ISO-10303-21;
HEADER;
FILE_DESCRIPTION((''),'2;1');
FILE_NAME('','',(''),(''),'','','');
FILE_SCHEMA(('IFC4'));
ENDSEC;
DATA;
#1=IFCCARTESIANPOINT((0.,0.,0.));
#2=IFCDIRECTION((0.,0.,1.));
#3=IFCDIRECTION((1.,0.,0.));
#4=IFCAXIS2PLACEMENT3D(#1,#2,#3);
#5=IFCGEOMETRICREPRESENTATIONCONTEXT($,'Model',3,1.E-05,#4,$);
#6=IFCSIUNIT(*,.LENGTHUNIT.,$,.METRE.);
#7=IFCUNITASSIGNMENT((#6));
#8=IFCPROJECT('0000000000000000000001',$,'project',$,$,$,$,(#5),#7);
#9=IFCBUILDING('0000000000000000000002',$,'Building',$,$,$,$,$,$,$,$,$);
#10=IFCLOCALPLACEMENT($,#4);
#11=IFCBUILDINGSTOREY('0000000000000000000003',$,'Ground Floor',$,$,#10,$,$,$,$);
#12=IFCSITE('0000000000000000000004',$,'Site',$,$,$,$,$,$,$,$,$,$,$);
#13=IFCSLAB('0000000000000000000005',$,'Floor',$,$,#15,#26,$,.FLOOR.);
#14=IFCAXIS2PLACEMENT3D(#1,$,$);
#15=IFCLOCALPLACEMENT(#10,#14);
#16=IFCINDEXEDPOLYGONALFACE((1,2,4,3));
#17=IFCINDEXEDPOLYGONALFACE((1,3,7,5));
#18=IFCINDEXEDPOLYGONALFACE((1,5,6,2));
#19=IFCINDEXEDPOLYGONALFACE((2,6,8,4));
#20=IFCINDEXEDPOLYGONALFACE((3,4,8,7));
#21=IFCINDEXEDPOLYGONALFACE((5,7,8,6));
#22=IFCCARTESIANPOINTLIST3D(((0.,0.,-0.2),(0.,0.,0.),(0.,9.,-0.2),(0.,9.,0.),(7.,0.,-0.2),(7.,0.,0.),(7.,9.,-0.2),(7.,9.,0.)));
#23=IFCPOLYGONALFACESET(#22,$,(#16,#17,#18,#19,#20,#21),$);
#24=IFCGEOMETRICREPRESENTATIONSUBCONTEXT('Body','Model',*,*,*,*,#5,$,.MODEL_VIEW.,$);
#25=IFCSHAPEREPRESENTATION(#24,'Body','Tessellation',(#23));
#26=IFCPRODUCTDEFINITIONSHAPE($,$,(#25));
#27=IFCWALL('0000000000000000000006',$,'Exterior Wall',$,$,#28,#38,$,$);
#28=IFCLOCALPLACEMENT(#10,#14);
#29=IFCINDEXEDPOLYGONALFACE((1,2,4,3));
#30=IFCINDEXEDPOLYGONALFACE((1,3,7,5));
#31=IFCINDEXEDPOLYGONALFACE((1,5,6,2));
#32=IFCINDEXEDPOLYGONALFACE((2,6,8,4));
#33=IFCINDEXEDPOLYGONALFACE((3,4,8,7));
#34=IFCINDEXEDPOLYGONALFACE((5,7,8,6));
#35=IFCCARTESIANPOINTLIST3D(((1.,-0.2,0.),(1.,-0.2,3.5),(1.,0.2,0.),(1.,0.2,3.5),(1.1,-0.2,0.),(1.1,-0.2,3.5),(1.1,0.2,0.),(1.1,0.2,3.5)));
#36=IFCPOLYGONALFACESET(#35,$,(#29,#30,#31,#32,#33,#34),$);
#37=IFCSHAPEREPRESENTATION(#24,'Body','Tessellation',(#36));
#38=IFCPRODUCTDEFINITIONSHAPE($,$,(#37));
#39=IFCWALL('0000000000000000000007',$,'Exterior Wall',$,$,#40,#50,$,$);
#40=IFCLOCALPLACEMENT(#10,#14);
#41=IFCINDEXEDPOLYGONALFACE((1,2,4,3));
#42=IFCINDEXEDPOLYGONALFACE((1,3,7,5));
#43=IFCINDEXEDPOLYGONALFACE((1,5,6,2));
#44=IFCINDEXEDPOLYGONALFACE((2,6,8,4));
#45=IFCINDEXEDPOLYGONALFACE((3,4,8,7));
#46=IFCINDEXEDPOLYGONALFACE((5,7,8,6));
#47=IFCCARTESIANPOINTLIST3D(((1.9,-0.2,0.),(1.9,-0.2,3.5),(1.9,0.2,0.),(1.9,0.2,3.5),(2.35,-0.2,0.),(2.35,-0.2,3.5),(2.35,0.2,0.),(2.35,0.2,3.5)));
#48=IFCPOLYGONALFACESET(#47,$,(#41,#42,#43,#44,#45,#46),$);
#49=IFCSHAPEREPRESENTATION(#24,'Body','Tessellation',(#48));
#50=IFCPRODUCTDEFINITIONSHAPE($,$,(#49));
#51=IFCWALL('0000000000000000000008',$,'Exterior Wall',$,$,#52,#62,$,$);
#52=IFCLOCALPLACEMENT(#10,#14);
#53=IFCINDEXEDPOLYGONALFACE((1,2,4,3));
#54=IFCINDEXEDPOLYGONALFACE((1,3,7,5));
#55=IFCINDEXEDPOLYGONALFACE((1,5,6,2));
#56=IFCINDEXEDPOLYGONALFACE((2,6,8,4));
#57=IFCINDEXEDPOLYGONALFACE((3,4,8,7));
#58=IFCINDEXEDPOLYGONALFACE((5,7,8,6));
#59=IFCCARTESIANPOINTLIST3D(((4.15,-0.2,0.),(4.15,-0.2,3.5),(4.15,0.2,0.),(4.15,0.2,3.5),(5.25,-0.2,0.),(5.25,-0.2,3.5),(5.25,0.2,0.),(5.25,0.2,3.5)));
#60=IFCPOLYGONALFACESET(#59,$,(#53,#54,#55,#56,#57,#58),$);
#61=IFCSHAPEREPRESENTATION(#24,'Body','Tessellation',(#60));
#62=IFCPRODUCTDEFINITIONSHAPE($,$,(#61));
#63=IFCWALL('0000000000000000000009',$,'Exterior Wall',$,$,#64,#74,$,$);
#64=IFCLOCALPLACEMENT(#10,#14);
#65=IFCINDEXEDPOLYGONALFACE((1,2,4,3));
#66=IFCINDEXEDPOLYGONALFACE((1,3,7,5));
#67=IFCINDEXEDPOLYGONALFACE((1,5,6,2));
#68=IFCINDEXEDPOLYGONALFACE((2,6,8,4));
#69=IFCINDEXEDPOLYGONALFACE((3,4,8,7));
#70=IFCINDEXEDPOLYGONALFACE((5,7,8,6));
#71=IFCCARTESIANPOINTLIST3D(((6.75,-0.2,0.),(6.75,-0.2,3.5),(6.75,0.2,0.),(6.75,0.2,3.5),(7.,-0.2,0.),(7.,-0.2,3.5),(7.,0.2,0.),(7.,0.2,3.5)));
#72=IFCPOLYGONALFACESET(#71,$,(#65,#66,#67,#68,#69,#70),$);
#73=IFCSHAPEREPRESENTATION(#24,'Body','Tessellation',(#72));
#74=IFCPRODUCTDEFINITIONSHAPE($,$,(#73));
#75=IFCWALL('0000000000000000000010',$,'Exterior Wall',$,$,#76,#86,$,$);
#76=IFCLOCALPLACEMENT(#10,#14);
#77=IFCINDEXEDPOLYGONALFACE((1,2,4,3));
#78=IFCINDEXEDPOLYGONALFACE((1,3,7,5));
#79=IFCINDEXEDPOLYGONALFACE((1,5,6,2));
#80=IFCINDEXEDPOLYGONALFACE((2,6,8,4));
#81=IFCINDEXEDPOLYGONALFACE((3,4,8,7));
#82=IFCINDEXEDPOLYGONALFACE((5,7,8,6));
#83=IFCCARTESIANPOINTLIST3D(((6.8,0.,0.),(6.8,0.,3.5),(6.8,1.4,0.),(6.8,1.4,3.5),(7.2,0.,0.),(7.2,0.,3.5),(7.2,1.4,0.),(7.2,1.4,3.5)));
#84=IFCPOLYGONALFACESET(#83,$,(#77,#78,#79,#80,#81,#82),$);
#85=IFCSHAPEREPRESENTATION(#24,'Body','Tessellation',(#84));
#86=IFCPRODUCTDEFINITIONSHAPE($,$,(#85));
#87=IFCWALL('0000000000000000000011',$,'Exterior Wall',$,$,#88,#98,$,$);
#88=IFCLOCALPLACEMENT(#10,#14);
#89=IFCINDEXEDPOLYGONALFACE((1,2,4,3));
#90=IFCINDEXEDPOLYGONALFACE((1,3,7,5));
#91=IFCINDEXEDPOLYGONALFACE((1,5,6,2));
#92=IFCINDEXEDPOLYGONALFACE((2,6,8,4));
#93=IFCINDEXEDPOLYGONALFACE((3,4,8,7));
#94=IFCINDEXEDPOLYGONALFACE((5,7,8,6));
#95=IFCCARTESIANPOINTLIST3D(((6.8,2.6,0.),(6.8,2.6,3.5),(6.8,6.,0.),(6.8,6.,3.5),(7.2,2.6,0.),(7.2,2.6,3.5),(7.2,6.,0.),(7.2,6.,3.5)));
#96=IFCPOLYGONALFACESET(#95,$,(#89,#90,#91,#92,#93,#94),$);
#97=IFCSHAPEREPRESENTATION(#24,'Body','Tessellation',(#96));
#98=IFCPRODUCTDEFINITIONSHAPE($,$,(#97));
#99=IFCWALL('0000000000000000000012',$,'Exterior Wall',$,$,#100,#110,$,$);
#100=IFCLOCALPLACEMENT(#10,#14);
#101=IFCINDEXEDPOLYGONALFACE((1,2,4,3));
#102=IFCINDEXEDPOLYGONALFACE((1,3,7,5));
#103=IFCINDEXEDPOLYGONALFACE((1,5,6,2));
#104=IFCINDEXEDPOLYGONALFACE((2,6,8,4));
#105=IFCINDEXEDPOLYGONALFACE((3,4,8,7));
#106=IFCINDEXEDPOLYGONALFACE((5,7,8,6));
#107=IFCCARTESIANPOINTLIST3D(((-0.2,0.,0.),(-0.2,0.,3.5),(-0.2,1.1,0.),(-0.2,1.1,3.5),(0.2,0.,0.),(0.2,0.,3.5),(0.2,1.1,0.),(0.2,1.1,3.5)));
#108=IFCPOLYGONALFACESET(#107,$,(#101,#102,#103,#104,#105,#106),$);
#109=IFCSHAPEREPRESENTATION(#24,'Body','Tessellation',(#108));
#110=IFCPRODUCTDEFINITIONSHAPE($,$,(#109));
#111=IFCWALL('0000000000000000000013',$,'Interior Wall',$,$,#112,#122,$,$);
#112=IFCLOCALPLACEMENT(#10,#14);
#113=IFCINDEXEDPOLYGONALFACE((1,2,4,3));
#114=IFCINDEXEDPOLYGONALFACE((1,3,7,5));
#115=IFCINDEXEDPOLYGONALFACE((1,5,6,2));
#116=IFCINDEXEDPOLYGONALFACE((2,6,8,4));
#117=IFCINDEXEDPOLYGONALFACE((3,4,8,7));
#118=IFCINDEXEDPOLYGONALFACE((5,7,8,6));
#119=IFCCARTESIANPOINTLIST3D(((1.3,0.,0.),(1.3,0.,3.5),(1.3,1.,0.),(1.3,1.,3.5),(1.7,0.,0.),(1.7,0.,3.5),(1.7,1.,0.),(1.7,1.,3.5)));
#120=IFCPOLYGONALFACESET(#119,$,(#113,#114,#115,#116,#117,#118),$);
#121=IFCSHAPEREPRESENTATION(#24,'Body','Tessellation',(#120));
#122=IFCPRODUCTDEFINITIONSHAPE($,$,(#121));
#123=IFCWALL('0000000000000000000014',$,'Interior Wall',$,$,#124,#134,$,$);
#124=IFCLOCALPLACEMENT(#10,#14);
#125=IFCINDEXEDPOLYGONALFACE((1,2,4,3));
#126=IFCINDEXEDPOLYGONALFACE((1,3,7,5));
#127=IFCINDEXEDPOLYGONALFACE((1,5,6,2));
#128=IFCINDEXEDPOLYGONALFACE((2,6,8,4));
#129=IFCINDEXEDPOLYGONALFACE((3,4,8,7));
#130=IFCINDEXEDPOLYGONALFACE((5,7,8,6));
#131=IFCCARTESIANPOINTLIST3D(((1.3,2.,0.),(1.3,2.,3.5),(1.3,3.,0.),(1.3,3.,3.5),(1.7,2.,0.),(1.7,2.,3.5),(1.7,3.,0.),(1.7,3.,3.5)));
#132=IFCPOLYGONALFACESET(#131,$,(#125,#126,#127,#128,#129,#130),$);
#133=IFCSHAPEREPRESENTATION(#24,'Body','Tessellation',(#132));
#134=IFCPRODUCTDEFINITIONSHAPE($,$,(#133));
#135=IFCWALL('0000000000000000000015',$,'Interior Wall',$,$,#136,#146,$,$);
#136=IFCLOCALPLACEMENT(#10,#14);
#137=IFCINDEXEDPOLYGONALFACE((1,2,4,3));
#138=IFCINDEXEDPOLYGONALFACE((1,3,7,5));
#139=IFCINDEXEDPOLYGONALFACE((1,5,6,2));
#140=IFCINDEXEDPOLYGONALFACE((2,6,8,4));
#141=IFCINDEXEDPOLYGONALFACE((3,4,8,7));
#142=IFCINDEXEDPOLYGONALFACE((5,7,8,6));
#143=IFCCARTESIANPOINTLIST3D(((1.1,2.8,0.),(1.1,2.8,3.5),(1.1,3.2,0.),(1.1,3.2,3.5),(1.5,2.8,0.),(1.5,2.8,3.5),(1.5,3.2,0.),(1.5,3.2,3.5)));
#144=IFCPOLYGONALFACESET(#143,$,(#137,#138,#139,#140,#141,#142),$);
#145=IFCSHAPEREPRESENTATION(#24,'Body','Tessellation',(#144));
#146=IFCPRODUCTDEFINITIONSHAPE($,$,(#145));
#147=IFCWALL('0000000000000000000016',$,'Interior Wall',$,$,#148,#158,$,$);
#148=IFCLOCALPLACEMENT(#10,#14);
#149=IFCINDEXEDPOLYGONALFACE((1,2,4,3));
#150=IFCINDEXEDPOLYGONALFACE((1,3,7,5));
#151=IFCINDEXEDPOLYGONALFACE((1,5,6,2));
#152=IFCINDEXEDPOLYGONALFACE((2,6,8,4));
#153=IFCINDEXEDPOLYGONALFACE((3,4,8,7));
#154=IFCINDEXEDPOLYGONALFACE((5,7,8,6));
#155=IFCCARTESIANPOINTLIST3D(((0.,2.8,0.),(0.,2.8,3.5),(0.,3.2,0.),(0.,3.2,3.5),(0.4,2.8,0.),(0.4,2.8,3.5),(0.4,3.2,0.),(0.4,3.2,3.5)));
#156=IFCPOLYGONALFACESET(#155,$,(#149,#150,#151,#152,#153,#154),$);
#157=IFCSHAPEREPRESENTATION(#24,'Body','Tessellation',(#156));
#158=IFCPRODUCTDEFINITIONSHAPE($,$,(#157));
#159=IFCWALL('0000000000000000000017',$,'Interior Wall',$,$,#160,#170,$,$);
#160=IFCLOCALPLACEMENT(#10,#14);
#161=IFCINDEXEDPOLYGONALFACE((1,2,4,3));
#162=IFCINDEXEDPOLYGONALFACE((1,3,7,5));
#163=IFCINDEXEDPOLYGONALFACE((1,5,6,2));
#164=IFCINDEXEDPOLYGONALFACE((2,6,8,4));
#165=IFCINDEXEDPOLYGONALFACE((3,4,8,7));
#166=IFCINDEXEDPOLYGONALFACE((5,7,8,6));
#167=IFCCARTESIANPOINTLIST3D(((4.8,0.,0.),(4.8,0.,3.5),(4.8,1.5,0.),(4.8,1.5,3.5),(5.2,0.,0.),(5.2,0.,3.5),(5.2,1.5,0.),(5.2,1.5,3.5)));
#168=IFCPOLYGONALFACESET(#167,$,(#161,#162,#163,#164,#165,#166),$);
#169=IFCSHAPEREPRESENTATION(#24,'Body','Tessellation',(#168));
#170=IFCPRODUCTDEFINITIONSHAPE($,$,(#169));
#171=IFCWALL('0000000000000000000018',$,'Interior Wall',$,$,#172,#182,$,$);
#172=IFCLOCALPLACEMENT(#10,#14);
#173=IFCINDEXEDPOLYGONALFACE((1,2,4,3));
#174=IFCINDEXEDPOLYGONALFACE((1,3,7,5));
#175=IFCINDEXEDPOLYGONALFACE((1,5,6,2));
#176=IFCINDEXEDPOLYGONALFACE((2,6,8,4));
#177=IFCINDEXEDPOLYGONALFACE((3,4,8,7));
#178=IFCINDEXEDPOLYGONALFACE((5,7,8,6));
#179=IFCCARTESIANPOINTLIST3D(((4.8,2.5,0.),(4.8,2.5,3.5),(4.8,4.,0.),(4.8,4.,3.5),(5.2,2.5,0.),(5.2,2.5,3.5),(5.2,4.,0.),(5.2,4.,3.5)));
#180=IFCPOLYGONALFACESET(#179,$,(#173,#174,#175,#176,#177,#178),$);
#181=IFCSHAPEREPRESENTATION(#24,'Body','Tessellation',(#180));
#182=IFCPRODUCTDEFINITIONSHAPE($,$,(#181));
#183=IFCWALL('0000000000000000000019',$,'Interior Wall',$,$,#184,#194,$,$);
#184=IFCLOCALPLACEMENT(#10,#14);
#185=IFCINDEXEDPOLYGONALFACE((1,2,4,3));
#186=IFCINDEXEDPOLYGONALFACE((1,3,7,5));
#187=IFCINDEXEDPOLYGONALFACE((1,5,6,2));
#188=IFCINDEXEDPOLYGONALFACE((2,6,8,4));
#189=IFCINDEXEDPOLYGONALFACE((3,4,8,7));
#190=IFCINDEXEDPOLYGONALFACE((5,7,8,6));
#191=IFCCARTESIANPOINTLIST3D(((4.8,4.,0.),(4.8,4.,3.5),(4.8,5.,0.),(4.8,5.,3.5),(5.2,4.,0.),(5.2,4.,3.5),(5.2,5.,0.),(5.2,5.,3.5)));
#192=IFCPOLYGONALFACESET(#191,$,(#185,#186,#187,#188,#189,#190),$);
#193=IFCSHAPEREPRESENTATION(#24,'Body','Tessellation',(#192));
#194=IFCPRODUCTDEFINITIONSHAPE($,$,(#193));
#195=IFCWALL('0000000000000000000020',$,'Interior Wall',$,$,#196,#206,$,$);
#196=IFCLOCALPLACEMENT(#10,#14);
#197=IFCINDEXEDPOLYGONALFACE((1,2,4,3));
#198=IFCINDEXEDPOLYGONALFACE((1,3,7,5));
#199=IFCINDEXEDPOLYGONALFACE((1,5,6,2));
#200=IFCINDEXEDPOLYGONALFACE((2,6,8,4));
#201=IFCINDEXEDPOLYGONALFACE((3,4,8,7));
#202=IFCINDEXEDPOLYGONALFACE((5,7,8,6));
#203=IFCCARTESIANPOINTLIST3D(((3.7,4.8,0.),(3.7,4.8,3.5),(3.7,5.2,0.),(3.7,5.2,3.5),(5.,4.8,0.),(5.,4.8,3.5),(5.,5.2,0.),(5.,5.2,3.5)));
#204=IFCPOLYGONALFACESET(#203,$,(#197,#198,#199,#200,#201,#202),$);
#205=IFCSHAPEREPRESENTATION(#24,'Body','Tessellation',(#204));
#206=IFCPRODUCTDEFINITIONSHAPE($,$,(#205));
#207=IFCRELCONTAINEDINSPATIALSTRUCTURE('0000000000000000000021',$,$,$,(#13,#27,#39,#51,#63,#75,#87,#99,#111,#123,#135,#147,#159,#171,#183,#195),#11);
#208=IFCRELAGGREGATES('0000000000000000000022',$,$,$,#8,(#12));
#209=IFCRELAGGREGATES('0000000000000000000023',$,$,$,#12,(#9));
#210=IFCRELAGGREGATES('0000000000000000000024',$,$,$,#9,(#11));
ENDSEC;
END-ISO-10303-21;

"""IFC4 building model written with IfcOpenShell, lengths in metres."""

from ifc_helpers import new_model, si_unit, frame, origin_with_axes, place, context, subcontext, project, spatial, indexed_curve, outline, extrude, element, save


model = new_model("IFC4")

# Units and contexts
model_context = context("Model", 3, precision=1e-05, world=origin_with_axes())
body_context = subcontext(model_context, "Body", "Model", "MODEL_VIEW")
ifc_project = project(units=[si_unit("LENGTHUNIT", "METRE")], contexts=[model_context])

# Site, building, storey
site = spatial("IfcSite", under=ifc_project, Name="Site")
building = spatial("IfcBuilding", under=site, Name="Building")
storey_placement = place(None, origin_with_axes())
storey = spatial("IfcBuildingStorey", under=building, at=storey_placement, Name="Ground Floor")

# Slab
slab_placement = place(storey_placement, frame((0.0, 0.0, -0.2), z_axis=(0.0, 0.0, 1.0), x_axis=(1.0, 0.0, 0.0)))
element("IfcSlab", 1, at=slab_placement, inside=storey, Name="Floor", PredefinedType="FLOOR", context=body_context, shape_type="SweptSolid", body=[
    extrude(outline(indexed_curve([(0.0, 0.0), (7.0, 0.0), (7.0, 9.0), (0.0, 9.0)])), None, (0.0, 0.0, 1.0), 0.2),
])

# Walls
wall_1_placement = place(storey_placement, frame((1.0, 0.0, 0.0), z_axis=(0.0, 0.0, 1.0), x_axis=(1.0, 0.0, 0.0)))
element("IfcWall", 2, at=wall_1_placement, inside=storey, Name="Exterior Wall", context=body_context, shape_type="SweptSolid", body=[
    extrude(outline(indexed_curve([(0.0, 0.0), (0.0, 0.4), (0.1, 0.4), (0.1, 0.0), (0.0, 0.0)], self_intersect=False)), frame((0.0, -0.2, 0.0), z_axis=(0.0, 0.0, 1.0), x_axis=(1.0, 0.0, 0.0)), (0.0, 0.0, 1.0), 3.5),
])
wall_2_placement = place(storey_placement, frame((1.9, 0.0, 0.0), z_axis=(0.0, 0.0, 1.0), x_axis=(1.0, 0.0, 0.0)))
element("IfcWall", 3, at=wall_2_placement, inside=storey, Name="Exterior Wall", context=body_context, shape_type="SweptSolid", body=[
    extrude(outline(indexed_curve([(0.0, 0.0), (0.0, 0.4), (0.45, 0.4), (0.45, 0.0), (0.0, 0.0)], self_intersect=False)), frame((0.0, -0.2, 0.0), z_axis=(0.0, 0.0, 1.0), x_axis=(1.0, 0.0, 0.0)), (0.0, 0.0, 1.0), 3.5),
])
wall_3_placement = place(storey_placement, frame((4.15, 0.0, 0.0), z_axis=(0.0, 0.0, 1.0), x_axis=(1.0, 0.0, 0.0)))
element("IfcWall", 4, at=wall_3_placement, inside=storey, Name="Exterior Wall", context=body_context, shape_type="SweptSolid", body=[
    extrude(outline(indexed_curve([(0.0, 0.0), (0.0, 0.4), (1.1, 0.4), (1.1, 0.0), (0.0, 0.0)], self_intersect=False)), frame((0.0, -0.2, 0.0), z_axis=(0.0, 0.0, 1.0), x_axis=(1.0, 0.0, 0.0)), (0.0, 0.0, 1.0), 3.5),
])
wall_4_placement = place(storey_placement, frame((6.75, 0.0, 0.0), z_axis=(0.0, 0.0, 1.0), x_axis=(1.0, 0.0, 0.0)))
element("IfcWall", 5, at=wall_4_placement, inside=storey, Name="Exterior Wall", context=body_context, shape_type="SweptSolid", body=[
    extrude(outline(indexed_curve([(0.0, 0.0), (0.0, 0.4), (0.25, 0.4), (0.25, 0.0), (0.0, 0.0)], self_intersect=False)), frame((0.0, -0.2, 0.0), z_axis=(0.0, 0.0, 1.0), x_axis=(1.0, 0.0, 0.0)), (0.0, 0.0, 1.0), 3.5),
])
wall_5_placement = place(storey_placement, frame((7.0, 0.0, 0.0), z_axis=(0.0, 0.0, 1.0), x_axis=(0.0, 1.0, 0.0)))
element("IfcWall", 6, at=wall_5_placement, inside=storey, Name="Exterior Wall", context=body_context, shape_type="SweptSolid", body=[
    extrude(outline(indexed_curve([(0.0, 0.0), (0.0, 0.4), (1.4, 0.4), (1.4, 0.0), (0.0, 0.0)], self_intersect=False)), frame((0.0, -0.2, 0.0), z_axis=(0.0, 0.0, 1.0), x_axis=(1.0, 0.0, 0.0)), (0.0, 0.0, 1.0), 3.5),
])
wall_6_placement = place(storey_placement, frame((7.0, 2.6, 0.0), z_axis=(0.0, 0.0, 1.0), x_axis=(0.0, 1.0, 0.0)))
element("IfcWall", 7, at=wall_6_placement, inside=storey, Name="Exterior Wall", context=body_context, shape_type="SweptSolid", body=[
    extrude(outline(indexed_curve([(0.0, 0.0), (0.0, 0.4), (3.4, 0.4), (3.4, 0.0), (0.0, 0.0)], self_intersect=False)), frame((0.0, -0.2, 0.0), z_axis=(0.0, 0.0, 1.0), x_axis=(1.0, 0.0, 0.0)), (0.0, 0.0, 1.0), 3.5),
])
wall_7_placement = place(storey_placement, frame((0.0, 1.1, 0.0), z_axis=(0.0, 0.0, 1.0), x_axis=(0.0, -1.0, 0.0)))
element("IfcWall", 8, at=wall_7_placement, inside=storey, Name="Exterior Wall", context=body_context, shape_type="SweptSolid", body=[
    extrude(outline(indexed_curve([(0.0, 0.0), (0.0, 0.4), (1.1, 0.4), (1.1, 0.0), (0.0, 0.0)], self_intersect=False)), frame((0.0, -0.2, 0.0), z_axis=(0.0, 0.0, 1.0), x_axis=(1.0, 0.0, 0.0)), (0.0, 0.0, 1.0), 3.5),
])
for number, where, z_axis, x_axis, name in (
    (9, (1.5, 0.0, 0.0), (0.0, 0.0, 1.0), (0.0, 1.0, 0.0), "Interior Wall"),
    (10, (1.5, 2.0, 0.0), (0.0, 0.0, 1.0), (0.0, 1.0, 0.0), "Interior Wall"),
):
    element("IfcWall", number, at=place(storey_placement, frame(where, z_axis=z_axis, x_axis=x_axis)), inside=storey, Name=name, context=body_context, shape_type="SweptSolid", body=[
        extrude(outline(indexed_curve([(0.0, 0.0), (0.0, 0.4), (1.0, 0.4), (1.0, 0.0), (0.0, 0.0)], self_intersect=False)), frame((0.0, -0.2, 0.0), z_axis=(0.0, 0.0, 1.0), x_axis=(1.0, 0.0, 0.0)), (0.0, 0.0, 1.0), 3.5),
    ])
for number, where, z_axis, x_axis, name in (
    (11, (1.5, 3.0, 0.0), (0.0, 0.0, 1.0), (-1.0, 0.0, 0.0), "Interior Wall"),
    (12, (0.4, 3.0, 0.0), (0.0, 0.0, 1.0), (-1.0, 0.0, 0.0), "Interior Wall"),
):
    element("IfcWall", number, at=place(storey_placement, frame(where, z_axis=z_axis, x_axis=x_axis)), inside=storey, Name=name, context=body_context, shape_type="SweptSolid", body=[
        extrude(outline(indexed_curve([(0.0, 0.0), (0.0, 0.4), (0.4, 0.4), (0.4, 0.0), (0.0, 0.0)], self_intersect=False)), frame((0.0, -0.2, 0.0), z_axis=(0.0, 0.0, 1.0), x_axis=(1.0, 0.0, 0.0)), (0.0, 0.0, 1.0), 3.5),
    ])
for number, where, z_axis, x_axis, name in (
    (13, (5.0, 0.0, 0.0), (0.0, 0.0, 1.0), (0.0, 1.0, 0.0), "Interior Wall"),
    (14, (5.0, 2.5, 0.0), (0.0, 0.0, 1.0), (0.0, 1.0, 0.0), "Interior Wall"),
):
    element("IfcWall", number, at=place(storey_placement, frame(where, z_axis=z_axis, x_axis=x_axis)), inside=storey, Name=name, context=body_context, shape_type="SweptSolid", body=[
        extrude(outline(indexed_curve([(0.0, 0.0), (0.0, 0.4), (1.5, 0.4), (1.5, 0.0), (0.0, 0.0)], self_intersect=False)), frame((0.0, -0.2, 0.0), z_axis=(0.0, 0.0, 1.0), x_axis=(1.0, 0.0, 0.0)), (0.0, 0.0, 1.0), 3.5),
    ])
wall_8_placement = place(storey_placement, frame((5.0, 4.0, 0.0), z_axis=(0.0, 0.0, 1.0), x_axis=(0.0, 1.0, 0.0)))
element("IfcWall", 15, at=wall_8_placement, inside=storey, Name="Interior Wall", context=body_context, shape_type="SweptSolid", body=[
    extrude(outline(indexed_curve([(0.0, 0.0), (0.0, 0.4), (1.0, 0.4), (1.0, 0.0), (0.0, 0.0)], self_intersect=False)), frame((0.0, -0.2, 0.0), z_axis=(0.0, 0.0, 1.0), x_axis=(1.0, 0.0, 0.0)), (0.0, 0.0, 1.0), 3.5),
])
wall_9_placement = place(storey_placement, frame((5.0, 5.0, 0.0), z_axis=(0.0, 0.0, 1.0), x_axis=(-1.0, 0.0, 0.0)))
element("IfcWall", 16, at=wall_9_placement, inside=storey, Name="Interior Wall", context=body_context, shape_type="SweptSolid", body=[
    extrude(outline(indexed_curve([(0.0, 0.0), (0.0, 0.4), (1.3, 0.4), (1.3, 0.0), (0.0, 0.0)], self_intersect=False)), frame((0.0, -0.2, 0.0), z_axis=(0.0, 0.0, 1.0), x_axis=(1.0, 0.0, 0.0)), (0.0, 0.0, 1.0), 3.5),
])

save(model, "model.ifc")
